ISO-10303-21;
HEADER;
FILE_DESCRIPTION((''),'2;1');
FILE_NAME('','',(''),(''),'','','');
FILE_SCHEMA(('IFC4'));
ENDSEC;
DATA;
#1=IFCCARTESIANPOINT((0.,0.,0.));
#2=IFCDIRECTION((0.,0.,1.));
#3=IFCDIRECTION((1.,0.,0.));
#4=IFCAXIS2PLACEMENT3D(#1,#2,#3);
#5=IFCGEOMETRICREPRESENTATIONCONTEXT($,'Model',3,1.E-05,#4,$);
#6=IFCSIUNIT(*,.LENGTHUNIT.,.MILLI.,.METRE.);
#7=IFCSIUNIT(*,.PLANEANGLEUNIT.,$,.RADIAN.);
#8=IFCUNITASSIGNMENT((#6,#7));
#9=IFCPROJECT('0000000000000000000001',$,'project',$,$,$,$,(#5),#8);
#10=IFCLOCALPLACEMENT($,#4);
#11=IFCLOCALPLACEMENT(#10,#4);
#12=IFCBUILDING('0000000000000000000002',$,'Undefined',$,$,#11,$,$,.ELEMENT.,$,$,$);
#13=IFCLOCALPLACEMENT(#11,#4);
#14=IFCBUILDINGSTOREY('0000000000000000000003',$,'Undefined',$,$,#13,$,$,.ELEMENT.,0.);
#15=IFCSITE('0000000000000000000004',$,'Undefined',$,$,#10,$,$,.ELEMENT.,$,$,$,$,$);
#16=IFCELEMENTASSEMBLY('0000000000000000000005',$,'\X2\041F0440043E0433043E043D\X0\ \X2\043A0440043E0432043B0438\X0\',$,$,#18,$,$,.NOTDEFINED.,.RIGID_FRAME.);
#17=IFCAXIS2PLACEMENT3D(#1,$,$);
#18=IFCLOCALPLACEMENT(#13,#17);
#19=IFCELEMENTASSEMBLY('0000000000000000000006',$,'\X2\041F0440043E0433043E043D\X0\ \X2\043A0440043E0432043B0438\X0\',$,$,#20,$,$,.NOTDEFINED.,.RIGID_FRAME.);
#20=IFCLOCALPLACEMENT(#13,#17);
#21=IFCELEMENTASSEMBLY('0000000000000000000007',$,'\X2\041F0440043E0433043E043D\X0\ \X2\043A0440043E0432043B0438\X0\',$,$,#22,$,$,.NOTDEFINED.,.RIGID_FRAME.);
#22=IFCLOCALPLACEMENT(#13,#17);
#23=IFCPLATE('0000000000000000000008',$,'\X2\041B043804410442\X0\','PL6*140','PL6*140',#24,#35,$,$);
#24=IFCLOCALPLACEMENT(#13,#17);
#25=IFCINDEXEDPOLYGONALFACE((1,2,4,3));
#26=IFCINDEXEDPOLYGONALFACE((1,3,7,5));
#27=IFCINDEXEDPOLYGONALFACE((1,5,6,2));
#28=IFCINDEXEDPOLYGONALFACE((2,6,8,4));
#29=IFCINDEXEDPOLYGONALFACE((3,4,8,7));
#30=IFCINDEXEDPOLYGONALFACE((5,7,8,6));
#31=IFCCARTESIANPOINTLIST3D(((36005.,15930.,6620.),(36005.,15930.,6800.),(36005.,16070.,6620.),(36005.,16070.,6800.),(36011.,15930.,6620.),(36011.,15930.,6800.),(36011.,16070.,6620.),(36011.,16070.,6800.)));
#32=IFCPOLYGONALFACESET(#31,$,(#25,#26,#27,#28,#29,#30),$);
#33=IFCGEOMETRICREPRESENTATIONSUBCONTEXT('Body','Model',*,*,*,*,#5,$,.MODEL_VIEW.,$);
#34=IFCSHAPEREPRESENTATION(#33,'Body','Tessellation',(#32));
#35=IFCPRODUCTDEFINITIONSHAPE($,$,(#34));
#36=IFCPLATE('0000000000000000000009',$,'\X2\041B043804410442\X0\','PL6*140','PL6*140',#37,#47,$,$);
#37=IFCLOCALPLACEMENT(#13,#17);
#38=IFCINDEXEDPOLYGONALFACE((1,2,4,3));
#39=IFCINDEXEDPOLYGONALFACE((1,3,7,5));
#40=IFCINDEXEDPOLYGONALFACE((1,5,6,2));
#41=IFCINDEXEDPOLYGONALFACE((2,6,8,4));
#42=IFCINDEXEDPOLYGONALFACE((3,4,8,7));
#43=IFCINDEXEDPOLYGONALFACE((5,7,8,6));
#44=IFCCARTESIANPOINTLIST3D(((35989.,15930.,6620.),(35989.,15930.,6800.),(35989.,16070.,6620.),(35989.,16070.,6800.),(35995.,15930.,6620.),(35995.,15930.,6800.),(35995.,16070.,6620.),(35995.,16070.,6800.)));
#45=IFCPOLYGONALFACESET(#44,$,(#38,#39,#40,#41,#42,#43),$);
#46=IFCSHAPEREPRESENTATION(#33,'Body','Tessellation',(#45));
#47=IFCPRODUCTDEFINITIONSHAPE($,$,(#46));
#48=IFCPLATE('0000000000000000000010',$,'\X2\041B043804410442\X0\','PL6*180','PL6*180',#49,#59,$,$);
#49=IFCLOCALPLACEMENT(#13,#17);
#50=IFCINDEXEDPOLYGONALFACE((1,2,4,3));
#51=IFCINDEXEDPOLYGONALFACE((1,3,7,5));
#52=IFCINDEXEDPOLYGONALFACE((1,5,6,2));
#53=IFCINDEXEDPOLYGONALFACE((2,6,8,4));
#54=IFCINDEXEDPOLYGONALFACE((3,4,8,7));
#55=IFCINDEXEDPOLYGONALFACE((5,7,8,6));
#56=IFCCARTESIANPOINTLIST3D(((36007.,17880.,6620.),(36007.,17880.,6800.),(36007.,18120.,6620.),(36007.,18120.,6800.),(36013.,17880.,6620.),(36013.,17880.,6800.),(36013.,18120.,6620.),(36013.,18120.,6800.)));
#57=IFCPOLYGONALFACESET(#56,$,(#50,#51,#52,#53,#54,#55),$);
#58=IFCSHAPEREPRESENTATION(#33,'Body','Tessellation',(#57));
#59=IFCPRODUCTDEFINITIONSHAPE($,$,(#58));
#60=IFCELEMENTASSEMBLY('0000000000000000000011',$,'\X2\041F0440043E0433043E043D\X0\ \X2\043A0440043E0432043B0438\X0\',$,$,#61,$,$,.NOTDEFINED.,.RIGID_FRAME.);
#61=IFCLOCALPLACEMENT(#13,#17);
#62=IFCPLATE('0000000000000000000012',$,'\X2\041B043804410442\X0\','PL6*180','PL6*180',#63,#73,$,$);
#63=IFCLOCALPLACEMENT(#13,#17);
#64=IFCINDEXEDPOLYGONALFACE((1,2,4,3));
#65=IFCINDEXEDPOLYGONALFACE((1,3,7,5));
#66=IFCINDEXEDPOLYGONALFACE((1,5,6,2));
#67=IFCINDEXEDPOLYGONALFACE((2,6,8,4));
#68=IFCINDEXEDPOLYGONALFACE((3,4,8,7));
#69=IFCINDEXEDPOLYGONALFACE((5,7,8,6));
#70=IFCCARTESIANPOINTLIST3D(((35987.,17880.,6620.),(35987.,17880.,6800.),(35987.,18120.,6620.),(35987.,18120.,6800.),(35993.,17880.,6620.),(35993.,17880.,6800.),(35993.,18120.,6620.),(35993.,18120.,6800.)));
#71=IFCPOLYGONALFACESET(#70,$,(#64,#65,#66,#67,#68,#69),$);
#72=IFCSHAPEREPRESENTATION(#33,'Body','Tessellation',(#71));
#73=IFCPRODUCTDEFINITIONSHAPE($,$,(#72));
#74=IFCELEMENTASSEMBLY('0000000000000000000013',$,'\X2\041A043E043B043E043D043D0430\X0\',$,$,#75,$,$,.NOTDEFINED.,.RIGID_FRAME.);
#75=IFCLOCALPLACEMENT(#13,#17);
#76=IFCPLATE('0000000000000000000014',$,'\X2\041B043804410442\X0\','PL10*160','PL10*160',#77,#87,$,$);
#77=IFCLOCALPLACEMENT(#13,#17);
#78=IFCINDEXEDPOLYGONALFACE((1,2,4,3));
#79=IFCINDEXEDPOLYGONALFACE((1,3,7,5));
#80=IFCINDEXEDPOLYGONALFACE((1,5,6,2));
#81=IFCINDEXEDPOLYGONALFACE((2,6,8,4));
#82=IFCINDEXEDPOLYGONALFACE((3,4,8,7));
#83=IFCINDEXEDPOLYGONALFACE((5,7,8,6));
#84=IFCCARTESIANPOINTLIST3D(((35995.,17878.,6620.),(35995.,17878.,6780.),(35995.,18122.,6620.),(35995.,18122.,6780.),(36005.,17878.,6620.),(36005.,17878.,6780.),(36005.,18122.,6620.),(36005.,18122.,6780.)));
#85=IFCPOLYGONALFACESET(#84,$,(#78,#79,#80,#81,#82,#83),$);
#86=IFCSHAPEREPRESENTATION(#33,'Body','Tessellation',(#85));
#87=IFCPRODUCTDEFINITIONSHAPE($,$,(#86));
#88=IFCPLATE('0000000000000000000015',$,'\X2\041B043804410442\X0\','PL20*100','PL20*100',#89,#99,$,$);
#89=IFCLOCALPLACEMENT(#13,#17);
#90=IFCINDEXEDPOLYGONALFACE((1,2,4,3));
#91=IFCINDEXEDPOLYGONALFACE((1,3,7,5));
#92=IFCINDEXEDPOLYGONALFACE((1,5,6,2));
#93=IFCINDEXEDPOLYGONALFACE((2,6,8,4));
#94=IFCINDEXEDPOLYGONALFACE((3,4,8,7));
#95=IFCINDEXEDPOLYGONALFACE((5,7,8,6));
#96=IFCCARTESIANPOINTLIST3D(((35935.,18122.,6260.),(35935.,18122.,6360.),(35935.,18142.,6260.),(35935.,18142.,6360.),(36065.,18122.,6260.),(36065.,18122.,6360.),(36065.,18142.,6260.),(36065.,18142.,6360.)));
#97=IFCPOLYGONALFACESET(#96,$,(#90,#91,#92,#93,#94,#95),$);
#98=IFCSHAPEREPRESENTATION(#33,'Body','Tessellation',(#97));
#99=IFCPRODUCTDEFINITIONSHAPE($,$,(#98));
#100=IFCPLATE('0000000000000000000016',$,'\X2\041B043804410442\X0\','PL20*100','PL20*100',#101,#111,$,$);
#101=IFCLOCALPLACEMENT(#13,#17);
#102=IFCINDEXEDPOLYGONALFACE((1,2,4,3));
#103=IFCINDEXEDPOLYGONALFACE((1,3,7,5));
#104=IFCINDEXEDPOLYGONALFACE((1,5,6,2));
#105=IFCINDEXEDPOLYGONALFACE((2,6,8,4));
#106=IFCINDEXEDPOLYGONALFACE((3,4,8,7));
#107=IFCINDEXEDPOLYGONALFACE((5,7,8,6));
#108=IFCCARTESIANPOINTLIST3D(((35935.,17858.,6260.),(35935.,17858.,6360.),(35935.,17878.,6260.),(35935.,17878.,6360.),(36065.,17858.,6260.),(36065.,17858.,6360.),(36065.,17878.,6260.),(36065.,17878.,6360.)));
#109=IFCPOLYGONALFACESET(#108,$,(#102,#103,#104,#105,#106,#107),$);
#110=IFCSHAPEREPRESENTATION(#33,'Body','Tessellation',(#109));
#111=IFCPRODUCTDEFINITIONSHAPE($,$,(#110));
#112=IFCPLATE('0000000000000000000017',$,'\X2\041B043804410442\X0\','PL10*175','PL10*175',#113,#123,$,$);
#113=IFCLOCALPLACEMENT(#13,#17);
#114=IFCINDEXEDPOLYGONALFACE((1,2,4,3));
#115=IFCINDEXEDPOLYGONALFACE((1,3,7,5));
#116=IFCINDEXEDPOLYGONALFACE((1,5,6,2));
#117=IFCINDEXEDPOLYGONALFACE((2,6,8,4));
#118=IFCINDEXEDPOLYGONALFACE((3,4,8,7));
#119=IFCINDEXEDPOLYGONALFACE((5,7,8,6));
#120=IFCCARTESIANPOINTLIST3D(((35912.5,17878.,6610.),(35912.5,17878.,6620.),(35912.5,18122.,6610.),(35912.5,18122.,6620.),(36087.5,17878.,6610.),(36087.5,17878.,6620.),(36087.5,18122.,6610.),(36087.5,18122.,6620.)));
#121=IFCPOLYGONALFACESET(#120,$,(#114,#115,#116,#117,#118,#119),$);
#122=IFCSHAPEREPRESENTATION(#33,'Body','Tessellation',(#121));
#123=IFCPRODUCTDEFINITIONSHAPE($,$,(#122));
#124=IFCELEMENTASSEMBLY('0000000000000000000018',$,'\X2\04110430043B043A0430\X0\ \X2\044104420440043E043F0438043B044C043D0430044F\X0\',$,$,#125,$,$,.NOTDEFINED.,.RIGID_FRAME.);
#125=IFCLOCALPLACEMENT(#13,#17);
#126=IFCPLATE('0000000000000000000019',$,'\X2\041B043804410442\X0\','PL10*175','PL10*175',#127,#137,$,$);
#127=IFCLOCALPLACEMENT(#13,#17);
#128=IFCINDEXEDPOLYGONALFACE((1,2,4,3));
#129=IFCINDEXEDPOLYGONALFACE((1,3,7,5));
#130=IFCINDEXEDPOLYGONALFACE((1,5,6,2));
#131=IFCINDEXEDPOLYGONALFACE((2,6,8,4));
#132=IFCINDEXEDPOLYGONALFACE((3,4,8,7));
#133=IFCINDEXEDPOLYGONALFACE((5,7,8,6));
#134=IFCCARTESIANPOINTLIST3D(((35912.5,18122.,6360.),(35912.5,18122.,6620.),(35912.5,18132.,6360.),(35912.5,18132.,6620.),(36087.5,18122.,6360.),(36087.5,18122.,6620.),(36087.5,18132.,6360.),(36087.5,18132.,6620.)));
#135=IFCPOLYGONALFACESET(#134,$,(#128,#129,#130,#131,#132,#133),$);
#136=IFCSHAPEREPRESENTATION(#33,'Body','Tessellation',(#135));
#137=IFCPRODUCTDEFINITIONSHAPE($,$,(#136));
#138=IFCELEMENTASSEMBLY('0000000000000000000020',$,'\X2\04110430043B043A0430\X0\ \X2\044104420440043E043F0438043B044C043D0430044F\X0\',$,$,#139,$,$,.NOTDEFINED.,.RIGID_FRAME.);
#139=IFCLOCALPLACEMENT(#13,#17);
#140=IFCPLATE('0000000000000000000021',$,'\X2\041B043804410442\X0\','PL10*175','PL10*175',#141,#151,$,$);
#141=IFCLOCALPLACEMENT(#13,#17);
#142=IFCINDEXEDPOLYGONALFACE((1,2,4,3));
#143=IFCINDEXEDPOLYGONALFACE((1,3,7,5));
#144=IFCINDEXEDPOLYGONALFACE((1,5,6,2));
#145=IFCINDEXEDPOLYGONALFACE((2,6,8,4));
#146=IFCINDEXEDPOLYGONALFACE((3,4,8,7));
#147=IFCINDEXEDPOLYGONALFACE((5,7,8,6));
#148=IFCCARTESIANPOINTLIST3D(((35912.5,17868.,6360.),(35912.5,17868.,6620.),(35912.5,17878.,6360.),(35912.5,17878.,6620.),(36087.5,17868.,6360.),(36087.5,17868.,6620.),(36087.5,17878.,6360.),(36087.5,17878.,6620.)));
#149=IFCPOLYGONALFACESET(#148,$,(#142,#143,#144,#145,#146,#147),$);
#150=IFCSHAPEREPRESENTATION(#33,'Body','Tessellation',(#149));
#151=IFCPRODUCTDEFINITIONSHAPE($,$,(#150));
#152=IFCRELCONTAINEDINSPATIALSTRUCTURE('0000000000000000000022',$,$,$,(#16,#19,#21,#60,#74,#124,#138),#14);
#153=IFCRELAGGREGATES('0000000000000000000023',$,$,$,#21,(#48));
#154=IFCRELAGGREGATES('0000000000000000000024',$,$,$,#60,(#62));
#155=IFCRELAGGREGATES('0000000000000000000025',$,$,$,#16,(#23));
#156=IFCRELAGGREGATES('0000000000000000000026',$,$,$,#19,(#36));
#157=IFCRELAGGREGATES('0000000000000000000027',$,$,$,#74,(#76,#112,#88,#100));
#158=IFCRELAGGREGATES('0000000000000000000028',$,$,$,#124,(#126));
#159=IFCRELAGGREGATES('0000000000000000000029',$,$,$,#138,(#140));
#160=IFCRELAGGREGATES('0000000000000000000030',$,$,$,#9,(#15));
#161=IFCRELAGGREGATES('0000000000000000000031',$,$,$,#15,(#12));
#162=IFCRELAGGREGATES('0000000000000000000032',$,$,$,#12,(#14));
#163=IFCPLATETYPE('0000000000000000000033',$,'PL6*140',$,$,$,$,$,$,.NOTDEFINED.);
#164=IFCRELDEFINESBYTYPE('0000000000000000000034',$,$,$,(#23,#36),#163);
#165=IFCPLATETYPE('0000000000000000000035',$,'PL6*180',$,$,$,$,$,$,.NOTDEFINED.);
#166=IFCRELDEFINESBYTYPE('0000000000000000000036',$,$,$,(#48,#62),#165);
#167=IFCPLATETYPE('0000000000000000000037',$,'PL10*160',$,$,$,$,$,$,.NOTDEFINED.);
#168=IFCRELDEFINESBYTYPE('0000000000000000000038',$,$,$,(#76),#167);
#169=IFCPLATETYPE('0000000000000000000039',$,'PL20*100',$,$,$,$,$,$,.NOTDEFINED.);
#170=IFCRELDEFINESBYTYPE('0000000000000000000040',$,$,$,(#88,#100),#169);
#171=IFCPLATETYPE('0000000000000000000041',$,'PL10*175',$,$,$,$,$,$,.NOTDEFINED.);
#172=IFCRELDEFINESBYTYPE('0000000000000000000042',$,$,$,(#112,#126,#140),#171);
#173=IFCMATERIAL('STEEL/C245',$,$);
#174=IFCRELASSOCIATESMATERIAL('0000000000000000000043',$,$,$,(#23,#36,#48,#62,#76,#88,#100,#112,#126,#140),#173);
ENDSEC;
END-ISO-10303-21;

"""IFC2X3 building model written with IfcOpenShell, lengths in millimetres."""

from ifc_helpers import new_model, si_unit, frame, origin_with_axes, place, context, subcontext, project, spatial, polyline, outline, extrude, material, type_object, element, aggregate, save


model = new_model("IFC2X3")

# Units and contexts
model_context = context("Model", 3, precision=1e-05, world=origin_with_axes())
body_context = subcontext(model_context, "Body", "Model", "MODEL_VIEW")
ifc_project = project(units=[si_unit("LENGTHUNIT", "METRE", prefix="MILLI"), si_unit("PLANEANGLEUNIT", "RADIAN")], contexts=[model_context])

# Site, building, storey
site_placement = place(None, origin_with_axes())
site = spatial("IfcSite", under=ifc_project, at=site_placement, Name="Undefined", CompositionType="ELEMENT")
building_placement = place(site_placement, origin_with_axes())
building = spatial("IfcBuilding", under=site, at=building_placement, Name="Undefined", CompositionType="ELEMENT")
storey_placement = place(building_placement, origin_with_axes())
storey = spatial("IfcBuildingStorey", under=building, at=storey_placement, Name="Undefined", CompositionType="ELEMENT", Elevation=0.0)

# Shared definitions
ifc_material_1 = material(Name="STEEL/C245")

# Element assemblies
assembly_1_placement = place(storey_placement, origin_with_axes())
assembly_1 = element("IfcElementAssembly", 1, at=assembly_1_placement, inside=storey, Name="Прогон кровли", AssemblyPlace="NOTDEFINED", PredefinedType="RIGID_FRAME")
assembly_2_placement = place(storey_placement, origin_with_axes())
assembly_2 = element("IfcElementAssembly", 2, at=assembly_2_placement, inside=storey, Name="Прогон кровли", AssemblyPlace="NOTDEFINED", PredefinedType="RIGID_FRAME")

# Element assembly
assembly_3_placement = place(storey_placement, origin_with_axes())
assembly_3 = element("IfcElementAssembly", 3, at=assembly_3_placement, inside=storey, Name="Прогон кровли", AssemblyPlace="NOTDEFINED", PredefinedType="RIGID_FRAME")

# Plates
plate_type_1 = type_object("IfcPlateType", Name="PL6*140", PredefinedType="NOTDEFINED")
plate_1_placement = place(assembly_1_placement, frame((36008.0, 16000.0, 6620.0), z_axis=(1.0, 0.0, 0.0), x_axis=(0.0, 0.0, 1.0)))
plate_1 = element("IfcPlate", 4, at=plate_1_placement, type_object=plate_type_1, material=ifc_material_1, Name="Лист", Description="PL6*140", ObjectType="PL6*140", context=body_context, shape_type="SweptSolid", body=[
    extrude(outline(polyline([(0.0, 70.0), (180.0, 70.0), (180.0, -70.0), (0.0, -70.0), (0.0, 70.0)])), frame((0.0, 0.0, -3.0), z_axis=(0.0, 0.0, 1.0), x_axis=(1.0, 0.0, 0.0)), (0.0, 0.0, 1.0), 6.0),
])
plate_2_placement = place(assembly_2_placement, frame((35992.0, 16000.0, 6620.0), z_axis=(-1.0, 0.0, 0.0), x_axis=(0.0, 0.0, 1.0)))
plate_2 = element("IfcPlate", 5, at=plate_2_placement, type_object=plate_type_1, material=ifc_material_1, Name="Лист", Description="PL6*140", ObjectType="PL6*140", context=body_context, shape_type="SweptSolid", body=[
    extrude(outline(polyline([(0.0, -70.0), (0.0, 70.0), (180.0, 70.0), (180.0, -70.0), (0.0, -70.0)])), frame((0.0, 0.0, -3.0), z_axis=(0.0, 0.0, 1.0), x_axis=(1.0, 0.0, 0.0)), (0.0, 0.0, 1.0), 6.0),
])
plate_type_2 = type_object("IfcPlateType", Name="PL6*180", PredefinedType="NOTDEFINED")
plate_3_placement = place(assembly_3_placement, frame((36010.0, 17880.0, 6620.0), z_axis=(-1.0, 0.0, 0.0), x_axis=(0.0, 0.0, 1.0)))
plate_3 = element("IfcPlate", 6, at=plate_3_placement, type_object=plate_type_2, material=ifc_material_1, Name="Лист", Description="PL6*180", ObjectType="PL6*180", context=body_context, shape_type="SweptSolid", body=[
    extrude(outline(polyline([(0.0, 0.0), (180.0, 0.0), (180.0, 240.0), (0.0, 240.0), (0.0, 0.0)])), frame((0.0, 0.0, -3.0), z_axis=(0.0, 0.0, 1.0), x_axis=(1.0, 0.0, 0.0)), (0.0, 0.0, 1.0), 6.0),
])
aggregate(assembly_3, [plate_3])

# Element assembly, plate
assembly_4_placement = place(storey_placement, origin_with_axes())
assembly_4 = element("IfcElementAssembly", 7, at=assembly_4_placement, inside=storey, Name="Прогон кровли", AssemblyPlace="NOTDEFINED", PredefinedType="RIGID_FRAME")
plate_4_placement = place(assembly_4_placement, frame((35990.0, 17880.0, 6620.0), z_axis=(-1.0, 0.0, 0.0), x_axis=(0.0, 0.0, 1.0)))
plate_4 = element("IfcPlate", 8, at=plate_4_placement, type_object=plate_type_2, material=ifc_material_1, Name="Лист", Description="PL6*180", ObjectType="PL6*180", context=body_context, shape_type="SweptSolid", body=[
    extrude(outline(polyline([(0.0, 0.0), (180.0, 0.0), (180.0, 240.0), (0.0, 240.0), (0.0, 0.0)])), frame((0.0, 0.0, -3.0), z_axis=(0.0, 0.0, 1.0), x_axis=(1.0, 0.0, 0.0)), (0.0, 0.0, 1.0), 6.0),
])
aggregate(assembly_4, [plate_4])

# Element assembly, plates
assembly_5_placement = place(storey_placement, origin_with_axes())
assembly_5 = element("IfcElementAssembly", 9, at=assembly_5_placement, inside=storey, Name="Колонна", AssemblyPlace="NOTDEFINED", PredefinedType="RIGID_FRAME")
plate_type_3 = type_object("IfcPlateType", Name="PL10*160", PredefinedType="NOTDEFINED")
plate_5_placement = place(assembly_5_placement, frame((36000.0, 17878.0, 6620.0), z_axis=(-1.0, 0.0, 0.0), x_axis=(0.0, 0.0, 1.0)))
plate_5 = element("IfcPlate", 10, at=plate_5_placement, type_object=plate_type_3, material=ifc_material_1, Name="Лист", Description="PL10*160", ObjectType="PL10*160", context=body_context, shape_type="SweptSolid", body=[
    extrude(outline(polyline([(0.0, 0.0), (160.0, 0.0), (160.0, 244.0), (0.0, 244.0), (0.0, 0.0)])), frame((0.0, 0.0, -5.0), z_axis=(0.0, 0.0, 1.0), x_axis=(1.0, 0.0, 0.0)), (0.0, 0.0, 1.0), 10.0),
])
plate_type_4 = type_object("IfcPlateType", Name="PL20*100", PredefinedType="NOTDEFINED")
plate_6_placement = place(assembly_5_placement, frame((36065.0, 18132.0, 6360.0), z_axis=(0.0, -1.0, 0.0), x_axis=(-1.0, 0.0, 0.0)))
plate_6 = element("IfcPlate", 11, at=plate_6_placement, type_object=plate_type_4, material=ifc_material_1, Name="Лист", Description="PL20*100", ObjectType="PL20*100", context=body_context, shape_type="SweptSolid", body=[
    extrude(outline(polyline([(0.0, 0.0), (130.0, 0.0), (130.0, 100.0), (0.0, 100.0), (0.0, 0.0)])), frame((0.0, 0.0, -10.0), z_axis=(0.0, 0.0, 1.0), x_axis=(1.0, 0.0, 0.0)), (0.0, 0.0, 1.0), 20.0),
])
plate_7_placement = place(assembly_5_placement, frame((36065.0, 17868.0, 6360.0), z_axis=(0.0, -1.0, 0.0), x_axis=(-1.0, 0.0, 0.0)))
plate_7 = element("IfcPlate", 12, at=plate_7_placement, type_object=plate_type_4, material=ifc_material_1, Name="Лист", Description="PL20*100", ObjectType="PL20*100", context=body_context, shape_type="SweptSolid", body=[
    extrude(outline(polyline([(0.0, 0.0), (130.0, 0.0), (130.0, 100.0), (0.0, 100.0), (0.0, 0.0)])), frame((0.0, 0.0, -10.0), z_axis=(0.0, 0.0, 1.0), x_axis=(1.0, 0.0, 0.0)), (0.0, 0.0, 1.0), 20.0),
])
plate_type_5 = type_object("IfcPlateType", Name="PL10*175", PredefinedType="NOTDEFINED")
plate_8_placement = place(assembly_5_placement, frame((35912.5, 17878.0, 6615.0), z_axis=(0.0, 0.0, -1.0), x_axis=(0.0, 1.0, 0.0)))
plate_8 = element("IfcPlate", 13, at=plate_8_placement, type_object=plate_type_5, material=ifc_material_1, Name="Лист", Description="PL10*175", ObjectType="PL10*175", context=body_context, shape_type="SweptSolid", body=[
    extrude(outline(polyline([(0.0, 0.0), (244.0, 0.0), (244.0, 175.0), (0.0, 175.0), (0.0, 0.0)])), frame((0.0, 0.0, -5.0), z_axis=(0.0, 0.0, 1.0), x_axis=(1.0, 0.0, 0.0)), (0.0, 0.0, 1.0), 10.0),
])

# Element assemblies, plates
assembly_6_placement = place(storey_placement, origin_with_axes())
assembly_6 = element("IfcElementAssembly", 14, at=assembly_6_placement, inside=storey, Name="Балка стропильная", AssemblyPlace="NOTDEFINED", PredefinedType="RIGID_FRAME")
plate_9_placement = place(assembly_6_placement, frame((36087.5, 18127.0, 6620.0), z_axis=(0.0, -1.0, 0.0), x_axis=(-1.0, 0.0, 0.0)))
plate_9 = element("IfcPlate", 15, at=plate_9_placement, type_object=plate_type_5, material=ifc_material_1, Name="Лист", Description="PL10*175", ObjectType="PL10*175", context=body_context, shape_type="SweptSolid", body=[
    extrude(outline(polyline([(0.0, 0.0), (175.0, 0.0), (175.0, 260.0), (0.0, 260.0), (0.0, 0.0)])), frame((0.0, 0.0, -5.0), z_axis=(0.0, 0.0, 1.0), x_axis=(1.0, 0.0, 0.0)), (0.0, 0.0, 1.0), 10.0),
])
assembly_7_placement = place(storey_placement, origin_with_axes())
assembly_7 = element("IfcElementAssembly", 16, at=assembly_7_placement, inside=storey, Name="Балка стропильная", AssemblyPlace="NOTDEFINED", PredefinedType="RIGID_FRAME")
plate_10_placement = place(assembly_7_placement, frame((36087.5, 17873.0, 6620.0), z_axis=(0.0, -1.0, 0.0), x_axis=(-1.0, 0.0, 0.0)))
plate_10 = element("IfcPlate", 17, at=plate_10_placement, type_object=plate_type_5, material=ifc_material_1, Name="Лист", Description="PL10*175", ObjectType="PL10*175", context=body_context, shape_type="SweptSolid", body=[
    extrude(outline(polyline([(0.0, 0.0), (175.0, 0.0), (175.0, 260.0), (0.0, 260.0), (0.0, 0.0)])), frame((0.0, 0.0, -5.0), z_axis=(0.0, 0.0, 1.0), x_axis=(1.0, 0.0, 0.0)), (0.0, 0.0, 1.0), 10.0),
])

aggregate(assembly_1, [plate_1])
aggregate(assembly_2, [plate_2])
aggregate(assembly_5, [plate_5, plate_8, plate_6, plate_7])
aggregate(assembly_6, [plate_9])
aggregate(assembly_7, [plate_10])

save(model, "model.ifc")
